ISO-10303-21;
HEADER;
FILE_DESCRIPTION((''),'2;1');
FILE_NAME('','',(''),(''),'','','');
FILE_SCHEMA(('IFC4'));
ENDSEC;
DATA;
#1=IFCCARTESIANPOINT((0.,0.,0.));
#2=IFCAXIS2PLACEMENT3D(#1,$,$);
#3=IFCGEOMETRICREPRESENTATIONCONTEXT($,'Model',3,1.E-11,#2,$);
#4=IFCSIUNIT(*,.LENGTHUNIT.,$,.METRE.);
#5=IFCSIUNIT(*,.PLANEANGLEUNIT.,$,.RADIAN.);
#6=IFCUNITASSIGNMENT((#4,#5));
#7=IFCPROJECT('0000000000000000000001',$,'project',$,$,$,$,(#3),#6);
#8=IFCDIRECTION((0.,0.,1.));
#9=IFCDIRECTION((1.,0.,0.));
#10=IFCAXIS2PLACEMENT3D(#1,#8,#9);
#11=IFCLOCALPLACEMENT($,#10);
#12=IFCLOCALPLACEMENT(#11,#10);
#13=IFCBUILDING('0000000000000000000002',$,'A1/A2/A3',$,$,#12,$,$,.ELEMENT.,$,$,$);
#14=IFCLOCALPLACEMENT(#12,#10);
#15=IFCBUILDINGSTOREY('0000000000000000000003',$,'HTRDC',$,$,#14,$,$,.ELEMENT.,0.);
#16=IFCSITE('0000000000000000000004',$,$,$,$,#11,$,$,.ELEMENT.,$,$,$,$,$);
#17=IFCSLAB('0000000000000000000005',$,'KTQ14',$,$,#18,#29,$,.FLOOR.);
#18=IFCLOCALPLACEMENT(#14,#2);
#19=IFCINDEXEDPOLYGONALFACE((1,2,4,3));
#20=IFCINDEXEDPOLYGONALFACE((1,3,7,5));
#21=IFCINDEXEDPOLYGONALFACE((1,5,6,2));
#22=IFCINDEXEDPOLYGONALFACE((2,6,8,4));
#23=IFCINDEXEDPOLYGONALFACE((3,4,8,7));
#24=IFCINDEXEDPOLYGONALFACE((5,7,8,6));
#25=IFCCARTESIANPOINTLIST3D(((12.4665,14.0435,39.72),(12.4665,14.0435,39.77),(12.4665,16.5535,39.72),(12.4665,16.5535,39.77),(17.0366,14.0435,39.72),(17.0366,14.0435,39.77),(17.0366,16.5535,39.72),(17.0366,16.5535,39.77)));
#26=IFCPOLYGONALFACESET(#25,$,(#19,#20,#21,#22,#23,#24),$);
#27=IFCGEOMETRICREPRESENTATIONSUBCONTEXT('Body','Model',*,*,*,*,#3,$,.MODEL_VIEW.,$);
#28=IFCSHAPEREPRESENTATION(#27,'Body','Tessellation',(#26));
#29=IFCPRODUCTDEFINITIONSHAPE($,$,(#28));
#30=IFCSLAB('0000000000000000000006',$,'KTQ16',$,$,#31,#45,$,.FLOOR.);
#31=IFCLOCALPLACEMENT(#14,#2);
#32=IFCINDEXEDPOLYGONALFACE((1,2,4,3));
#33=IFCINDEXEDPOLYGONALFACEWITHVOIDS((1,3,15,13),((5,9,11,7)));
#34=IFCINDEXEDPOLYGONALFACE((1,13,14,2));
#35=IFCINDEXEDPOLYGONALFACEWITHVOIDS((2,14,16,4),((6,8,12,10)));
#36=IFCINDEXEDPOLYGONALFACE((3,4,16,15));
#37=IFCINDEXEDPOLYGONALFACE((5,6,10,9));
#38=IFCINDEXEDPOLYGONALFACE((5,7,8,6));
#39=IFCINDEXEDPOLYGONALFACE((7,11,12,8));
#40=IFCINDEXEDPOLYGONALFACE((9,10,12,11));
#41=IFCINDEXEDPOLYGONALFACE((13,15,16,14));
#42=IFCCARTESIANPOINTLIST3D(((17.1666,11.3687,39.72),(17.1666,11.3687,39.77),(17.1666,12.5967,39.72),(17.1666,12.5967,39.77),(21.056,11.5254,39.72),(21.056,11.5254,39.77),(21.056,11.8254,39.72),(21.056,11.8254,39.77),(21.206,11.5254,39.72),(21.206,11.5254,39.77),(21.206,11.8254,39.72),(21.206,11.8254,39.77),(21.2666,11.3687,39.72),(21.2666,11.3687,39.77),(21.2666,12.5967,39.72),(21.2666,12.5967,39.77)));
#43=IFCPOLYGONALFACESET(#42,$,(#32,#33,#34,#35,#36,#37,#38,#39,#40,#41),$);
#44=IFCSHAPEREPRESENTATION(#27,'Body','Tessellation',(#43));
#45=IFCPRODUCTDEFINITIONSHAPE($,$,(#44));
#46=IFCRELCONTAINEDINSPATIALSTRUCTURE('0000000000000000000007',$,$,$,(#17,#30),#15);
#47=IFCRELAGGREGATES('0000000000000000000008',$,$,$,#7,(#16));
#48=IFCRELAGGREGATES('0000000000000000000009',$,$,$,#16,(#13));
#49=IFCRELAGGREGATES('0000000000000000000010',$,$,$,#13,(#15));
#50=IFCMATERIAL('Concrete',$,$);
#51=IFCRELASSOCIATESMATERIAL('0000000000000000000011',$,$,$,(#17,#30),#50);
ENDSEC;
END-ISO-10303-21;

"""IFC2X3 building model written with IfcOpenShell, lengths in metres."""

from ifc_helpers import new_model, si_unit, frame, origin, origin_with_axes, place, context, subcontext, project, spatial, polyline, outline, extrude, material, element, save


model = new_model("IFC2X3")

# Units and contexts
model_context = context("Model", 3, precision=1e-11, world=origin())
body_context = subcontext(model_context, "Body", "Model", "MODEL_VIEW")
ifc_project = project(units=[si_unit("LENGTHUNIT", "METRE"), si_unit("PLANEANGLEUNIT", "RADIAN")], contexts=[model_context])

# Site, building, storey
site_placement = place(None, origin_with_axes())
site = spatial("IfcSite", under=ifc_project, at=site_placement, CompositionType="ELEMENT")
building_placement = place(site_placement, origin_with_axes())
building = spatial("IfcBuilding", under=site, at=building_placement, Name="A1/A2/A3", CompositionType="ELEMENT")
storey_placement = place(building_placement, origin_with_axes())
storey = spatial("IfcBuildingStorey", under=building, at=storey_placement, Name="HTRDC", CompositionType="ELEMENT", Elevation=0.0)

# Shared definitions
ifc_material = material(Name="Concrete")

# Slab
slab_1_placement = place(storey_placement, frame((12.4665, 14.0435, 39.72), z_axis=(0.0, 0.0, 1.0), x_axis=(1.0, 0.0, 0.0)))
element("IfcSlab", 1, at=slab_1_placement, inside=storey, material=ifc_material, Name="KTQ14", PredefinedType="FLOOR", context=body_context, shape_type="SweptSolid", body=[
    extrude(outline(polyline([(0.0, 0.0), (0.0, -4.5701), (2.51, -4.5701), (2.51, 0.0), (0.0, 0.0)])), frame((0.0, 0.0, 0.0), z_axis=(0.0, 0.0, 1.0), x_axis=(0.0, 1.0, 0.0)), (0.0, 0.0, 1.0), 0.05),
])

# Slab, opening
slab_2_placement = place(storey_placement, frame((17.1666, 11.3687, 39.72), z_axis=(0.0, 0.0, 1.0), x_axis=(1.0, 0.0, 0.0)))
slab_2 = element("IfcSlab", 2, at=slab_2_placement, inside=storey, material=ifc_material, Name="KTQ16", PredefinedType="FLOOR", context=body_context, shape_type="SweptSolid", body=[
    extrude(outline(polyline([(0.0, 0.0), (0.0, -4.1), (1.228, -4.1), (1.228, 0.0), (0.0, 0.0)])), frame((0.0, 0.0, 0.0), z_axis=(0.0, 0.0, 1.0), x_axis=(0.0, 1.0, 0.0)), (0.0, 0.0, 1.0), 0.05),
])
opening_1_placement = place(slab_2_placement, origin_with_axes())
element("IfcOpeningElement", 3, at=opening_1_placement, cuts=slab_2, ObjectType="Opening", context=body_context, shape_type="SweptSolid", body=[
    extrude(outline(polyline([(0.1566, -3.8894), (0.1566, -4.0394), (0.4566, -4.0394), (0.4566, -3.8894), (0.1566, -3.8894)])), frame((0.0, 0.0, 0.0), z_axis=(0.0, 0.0, 1.0), x_axis=(0.0, 1.0, 0.0)), (0.0, 0.0, 1.0), 0.05),
])

save(model, "model.ifc")
